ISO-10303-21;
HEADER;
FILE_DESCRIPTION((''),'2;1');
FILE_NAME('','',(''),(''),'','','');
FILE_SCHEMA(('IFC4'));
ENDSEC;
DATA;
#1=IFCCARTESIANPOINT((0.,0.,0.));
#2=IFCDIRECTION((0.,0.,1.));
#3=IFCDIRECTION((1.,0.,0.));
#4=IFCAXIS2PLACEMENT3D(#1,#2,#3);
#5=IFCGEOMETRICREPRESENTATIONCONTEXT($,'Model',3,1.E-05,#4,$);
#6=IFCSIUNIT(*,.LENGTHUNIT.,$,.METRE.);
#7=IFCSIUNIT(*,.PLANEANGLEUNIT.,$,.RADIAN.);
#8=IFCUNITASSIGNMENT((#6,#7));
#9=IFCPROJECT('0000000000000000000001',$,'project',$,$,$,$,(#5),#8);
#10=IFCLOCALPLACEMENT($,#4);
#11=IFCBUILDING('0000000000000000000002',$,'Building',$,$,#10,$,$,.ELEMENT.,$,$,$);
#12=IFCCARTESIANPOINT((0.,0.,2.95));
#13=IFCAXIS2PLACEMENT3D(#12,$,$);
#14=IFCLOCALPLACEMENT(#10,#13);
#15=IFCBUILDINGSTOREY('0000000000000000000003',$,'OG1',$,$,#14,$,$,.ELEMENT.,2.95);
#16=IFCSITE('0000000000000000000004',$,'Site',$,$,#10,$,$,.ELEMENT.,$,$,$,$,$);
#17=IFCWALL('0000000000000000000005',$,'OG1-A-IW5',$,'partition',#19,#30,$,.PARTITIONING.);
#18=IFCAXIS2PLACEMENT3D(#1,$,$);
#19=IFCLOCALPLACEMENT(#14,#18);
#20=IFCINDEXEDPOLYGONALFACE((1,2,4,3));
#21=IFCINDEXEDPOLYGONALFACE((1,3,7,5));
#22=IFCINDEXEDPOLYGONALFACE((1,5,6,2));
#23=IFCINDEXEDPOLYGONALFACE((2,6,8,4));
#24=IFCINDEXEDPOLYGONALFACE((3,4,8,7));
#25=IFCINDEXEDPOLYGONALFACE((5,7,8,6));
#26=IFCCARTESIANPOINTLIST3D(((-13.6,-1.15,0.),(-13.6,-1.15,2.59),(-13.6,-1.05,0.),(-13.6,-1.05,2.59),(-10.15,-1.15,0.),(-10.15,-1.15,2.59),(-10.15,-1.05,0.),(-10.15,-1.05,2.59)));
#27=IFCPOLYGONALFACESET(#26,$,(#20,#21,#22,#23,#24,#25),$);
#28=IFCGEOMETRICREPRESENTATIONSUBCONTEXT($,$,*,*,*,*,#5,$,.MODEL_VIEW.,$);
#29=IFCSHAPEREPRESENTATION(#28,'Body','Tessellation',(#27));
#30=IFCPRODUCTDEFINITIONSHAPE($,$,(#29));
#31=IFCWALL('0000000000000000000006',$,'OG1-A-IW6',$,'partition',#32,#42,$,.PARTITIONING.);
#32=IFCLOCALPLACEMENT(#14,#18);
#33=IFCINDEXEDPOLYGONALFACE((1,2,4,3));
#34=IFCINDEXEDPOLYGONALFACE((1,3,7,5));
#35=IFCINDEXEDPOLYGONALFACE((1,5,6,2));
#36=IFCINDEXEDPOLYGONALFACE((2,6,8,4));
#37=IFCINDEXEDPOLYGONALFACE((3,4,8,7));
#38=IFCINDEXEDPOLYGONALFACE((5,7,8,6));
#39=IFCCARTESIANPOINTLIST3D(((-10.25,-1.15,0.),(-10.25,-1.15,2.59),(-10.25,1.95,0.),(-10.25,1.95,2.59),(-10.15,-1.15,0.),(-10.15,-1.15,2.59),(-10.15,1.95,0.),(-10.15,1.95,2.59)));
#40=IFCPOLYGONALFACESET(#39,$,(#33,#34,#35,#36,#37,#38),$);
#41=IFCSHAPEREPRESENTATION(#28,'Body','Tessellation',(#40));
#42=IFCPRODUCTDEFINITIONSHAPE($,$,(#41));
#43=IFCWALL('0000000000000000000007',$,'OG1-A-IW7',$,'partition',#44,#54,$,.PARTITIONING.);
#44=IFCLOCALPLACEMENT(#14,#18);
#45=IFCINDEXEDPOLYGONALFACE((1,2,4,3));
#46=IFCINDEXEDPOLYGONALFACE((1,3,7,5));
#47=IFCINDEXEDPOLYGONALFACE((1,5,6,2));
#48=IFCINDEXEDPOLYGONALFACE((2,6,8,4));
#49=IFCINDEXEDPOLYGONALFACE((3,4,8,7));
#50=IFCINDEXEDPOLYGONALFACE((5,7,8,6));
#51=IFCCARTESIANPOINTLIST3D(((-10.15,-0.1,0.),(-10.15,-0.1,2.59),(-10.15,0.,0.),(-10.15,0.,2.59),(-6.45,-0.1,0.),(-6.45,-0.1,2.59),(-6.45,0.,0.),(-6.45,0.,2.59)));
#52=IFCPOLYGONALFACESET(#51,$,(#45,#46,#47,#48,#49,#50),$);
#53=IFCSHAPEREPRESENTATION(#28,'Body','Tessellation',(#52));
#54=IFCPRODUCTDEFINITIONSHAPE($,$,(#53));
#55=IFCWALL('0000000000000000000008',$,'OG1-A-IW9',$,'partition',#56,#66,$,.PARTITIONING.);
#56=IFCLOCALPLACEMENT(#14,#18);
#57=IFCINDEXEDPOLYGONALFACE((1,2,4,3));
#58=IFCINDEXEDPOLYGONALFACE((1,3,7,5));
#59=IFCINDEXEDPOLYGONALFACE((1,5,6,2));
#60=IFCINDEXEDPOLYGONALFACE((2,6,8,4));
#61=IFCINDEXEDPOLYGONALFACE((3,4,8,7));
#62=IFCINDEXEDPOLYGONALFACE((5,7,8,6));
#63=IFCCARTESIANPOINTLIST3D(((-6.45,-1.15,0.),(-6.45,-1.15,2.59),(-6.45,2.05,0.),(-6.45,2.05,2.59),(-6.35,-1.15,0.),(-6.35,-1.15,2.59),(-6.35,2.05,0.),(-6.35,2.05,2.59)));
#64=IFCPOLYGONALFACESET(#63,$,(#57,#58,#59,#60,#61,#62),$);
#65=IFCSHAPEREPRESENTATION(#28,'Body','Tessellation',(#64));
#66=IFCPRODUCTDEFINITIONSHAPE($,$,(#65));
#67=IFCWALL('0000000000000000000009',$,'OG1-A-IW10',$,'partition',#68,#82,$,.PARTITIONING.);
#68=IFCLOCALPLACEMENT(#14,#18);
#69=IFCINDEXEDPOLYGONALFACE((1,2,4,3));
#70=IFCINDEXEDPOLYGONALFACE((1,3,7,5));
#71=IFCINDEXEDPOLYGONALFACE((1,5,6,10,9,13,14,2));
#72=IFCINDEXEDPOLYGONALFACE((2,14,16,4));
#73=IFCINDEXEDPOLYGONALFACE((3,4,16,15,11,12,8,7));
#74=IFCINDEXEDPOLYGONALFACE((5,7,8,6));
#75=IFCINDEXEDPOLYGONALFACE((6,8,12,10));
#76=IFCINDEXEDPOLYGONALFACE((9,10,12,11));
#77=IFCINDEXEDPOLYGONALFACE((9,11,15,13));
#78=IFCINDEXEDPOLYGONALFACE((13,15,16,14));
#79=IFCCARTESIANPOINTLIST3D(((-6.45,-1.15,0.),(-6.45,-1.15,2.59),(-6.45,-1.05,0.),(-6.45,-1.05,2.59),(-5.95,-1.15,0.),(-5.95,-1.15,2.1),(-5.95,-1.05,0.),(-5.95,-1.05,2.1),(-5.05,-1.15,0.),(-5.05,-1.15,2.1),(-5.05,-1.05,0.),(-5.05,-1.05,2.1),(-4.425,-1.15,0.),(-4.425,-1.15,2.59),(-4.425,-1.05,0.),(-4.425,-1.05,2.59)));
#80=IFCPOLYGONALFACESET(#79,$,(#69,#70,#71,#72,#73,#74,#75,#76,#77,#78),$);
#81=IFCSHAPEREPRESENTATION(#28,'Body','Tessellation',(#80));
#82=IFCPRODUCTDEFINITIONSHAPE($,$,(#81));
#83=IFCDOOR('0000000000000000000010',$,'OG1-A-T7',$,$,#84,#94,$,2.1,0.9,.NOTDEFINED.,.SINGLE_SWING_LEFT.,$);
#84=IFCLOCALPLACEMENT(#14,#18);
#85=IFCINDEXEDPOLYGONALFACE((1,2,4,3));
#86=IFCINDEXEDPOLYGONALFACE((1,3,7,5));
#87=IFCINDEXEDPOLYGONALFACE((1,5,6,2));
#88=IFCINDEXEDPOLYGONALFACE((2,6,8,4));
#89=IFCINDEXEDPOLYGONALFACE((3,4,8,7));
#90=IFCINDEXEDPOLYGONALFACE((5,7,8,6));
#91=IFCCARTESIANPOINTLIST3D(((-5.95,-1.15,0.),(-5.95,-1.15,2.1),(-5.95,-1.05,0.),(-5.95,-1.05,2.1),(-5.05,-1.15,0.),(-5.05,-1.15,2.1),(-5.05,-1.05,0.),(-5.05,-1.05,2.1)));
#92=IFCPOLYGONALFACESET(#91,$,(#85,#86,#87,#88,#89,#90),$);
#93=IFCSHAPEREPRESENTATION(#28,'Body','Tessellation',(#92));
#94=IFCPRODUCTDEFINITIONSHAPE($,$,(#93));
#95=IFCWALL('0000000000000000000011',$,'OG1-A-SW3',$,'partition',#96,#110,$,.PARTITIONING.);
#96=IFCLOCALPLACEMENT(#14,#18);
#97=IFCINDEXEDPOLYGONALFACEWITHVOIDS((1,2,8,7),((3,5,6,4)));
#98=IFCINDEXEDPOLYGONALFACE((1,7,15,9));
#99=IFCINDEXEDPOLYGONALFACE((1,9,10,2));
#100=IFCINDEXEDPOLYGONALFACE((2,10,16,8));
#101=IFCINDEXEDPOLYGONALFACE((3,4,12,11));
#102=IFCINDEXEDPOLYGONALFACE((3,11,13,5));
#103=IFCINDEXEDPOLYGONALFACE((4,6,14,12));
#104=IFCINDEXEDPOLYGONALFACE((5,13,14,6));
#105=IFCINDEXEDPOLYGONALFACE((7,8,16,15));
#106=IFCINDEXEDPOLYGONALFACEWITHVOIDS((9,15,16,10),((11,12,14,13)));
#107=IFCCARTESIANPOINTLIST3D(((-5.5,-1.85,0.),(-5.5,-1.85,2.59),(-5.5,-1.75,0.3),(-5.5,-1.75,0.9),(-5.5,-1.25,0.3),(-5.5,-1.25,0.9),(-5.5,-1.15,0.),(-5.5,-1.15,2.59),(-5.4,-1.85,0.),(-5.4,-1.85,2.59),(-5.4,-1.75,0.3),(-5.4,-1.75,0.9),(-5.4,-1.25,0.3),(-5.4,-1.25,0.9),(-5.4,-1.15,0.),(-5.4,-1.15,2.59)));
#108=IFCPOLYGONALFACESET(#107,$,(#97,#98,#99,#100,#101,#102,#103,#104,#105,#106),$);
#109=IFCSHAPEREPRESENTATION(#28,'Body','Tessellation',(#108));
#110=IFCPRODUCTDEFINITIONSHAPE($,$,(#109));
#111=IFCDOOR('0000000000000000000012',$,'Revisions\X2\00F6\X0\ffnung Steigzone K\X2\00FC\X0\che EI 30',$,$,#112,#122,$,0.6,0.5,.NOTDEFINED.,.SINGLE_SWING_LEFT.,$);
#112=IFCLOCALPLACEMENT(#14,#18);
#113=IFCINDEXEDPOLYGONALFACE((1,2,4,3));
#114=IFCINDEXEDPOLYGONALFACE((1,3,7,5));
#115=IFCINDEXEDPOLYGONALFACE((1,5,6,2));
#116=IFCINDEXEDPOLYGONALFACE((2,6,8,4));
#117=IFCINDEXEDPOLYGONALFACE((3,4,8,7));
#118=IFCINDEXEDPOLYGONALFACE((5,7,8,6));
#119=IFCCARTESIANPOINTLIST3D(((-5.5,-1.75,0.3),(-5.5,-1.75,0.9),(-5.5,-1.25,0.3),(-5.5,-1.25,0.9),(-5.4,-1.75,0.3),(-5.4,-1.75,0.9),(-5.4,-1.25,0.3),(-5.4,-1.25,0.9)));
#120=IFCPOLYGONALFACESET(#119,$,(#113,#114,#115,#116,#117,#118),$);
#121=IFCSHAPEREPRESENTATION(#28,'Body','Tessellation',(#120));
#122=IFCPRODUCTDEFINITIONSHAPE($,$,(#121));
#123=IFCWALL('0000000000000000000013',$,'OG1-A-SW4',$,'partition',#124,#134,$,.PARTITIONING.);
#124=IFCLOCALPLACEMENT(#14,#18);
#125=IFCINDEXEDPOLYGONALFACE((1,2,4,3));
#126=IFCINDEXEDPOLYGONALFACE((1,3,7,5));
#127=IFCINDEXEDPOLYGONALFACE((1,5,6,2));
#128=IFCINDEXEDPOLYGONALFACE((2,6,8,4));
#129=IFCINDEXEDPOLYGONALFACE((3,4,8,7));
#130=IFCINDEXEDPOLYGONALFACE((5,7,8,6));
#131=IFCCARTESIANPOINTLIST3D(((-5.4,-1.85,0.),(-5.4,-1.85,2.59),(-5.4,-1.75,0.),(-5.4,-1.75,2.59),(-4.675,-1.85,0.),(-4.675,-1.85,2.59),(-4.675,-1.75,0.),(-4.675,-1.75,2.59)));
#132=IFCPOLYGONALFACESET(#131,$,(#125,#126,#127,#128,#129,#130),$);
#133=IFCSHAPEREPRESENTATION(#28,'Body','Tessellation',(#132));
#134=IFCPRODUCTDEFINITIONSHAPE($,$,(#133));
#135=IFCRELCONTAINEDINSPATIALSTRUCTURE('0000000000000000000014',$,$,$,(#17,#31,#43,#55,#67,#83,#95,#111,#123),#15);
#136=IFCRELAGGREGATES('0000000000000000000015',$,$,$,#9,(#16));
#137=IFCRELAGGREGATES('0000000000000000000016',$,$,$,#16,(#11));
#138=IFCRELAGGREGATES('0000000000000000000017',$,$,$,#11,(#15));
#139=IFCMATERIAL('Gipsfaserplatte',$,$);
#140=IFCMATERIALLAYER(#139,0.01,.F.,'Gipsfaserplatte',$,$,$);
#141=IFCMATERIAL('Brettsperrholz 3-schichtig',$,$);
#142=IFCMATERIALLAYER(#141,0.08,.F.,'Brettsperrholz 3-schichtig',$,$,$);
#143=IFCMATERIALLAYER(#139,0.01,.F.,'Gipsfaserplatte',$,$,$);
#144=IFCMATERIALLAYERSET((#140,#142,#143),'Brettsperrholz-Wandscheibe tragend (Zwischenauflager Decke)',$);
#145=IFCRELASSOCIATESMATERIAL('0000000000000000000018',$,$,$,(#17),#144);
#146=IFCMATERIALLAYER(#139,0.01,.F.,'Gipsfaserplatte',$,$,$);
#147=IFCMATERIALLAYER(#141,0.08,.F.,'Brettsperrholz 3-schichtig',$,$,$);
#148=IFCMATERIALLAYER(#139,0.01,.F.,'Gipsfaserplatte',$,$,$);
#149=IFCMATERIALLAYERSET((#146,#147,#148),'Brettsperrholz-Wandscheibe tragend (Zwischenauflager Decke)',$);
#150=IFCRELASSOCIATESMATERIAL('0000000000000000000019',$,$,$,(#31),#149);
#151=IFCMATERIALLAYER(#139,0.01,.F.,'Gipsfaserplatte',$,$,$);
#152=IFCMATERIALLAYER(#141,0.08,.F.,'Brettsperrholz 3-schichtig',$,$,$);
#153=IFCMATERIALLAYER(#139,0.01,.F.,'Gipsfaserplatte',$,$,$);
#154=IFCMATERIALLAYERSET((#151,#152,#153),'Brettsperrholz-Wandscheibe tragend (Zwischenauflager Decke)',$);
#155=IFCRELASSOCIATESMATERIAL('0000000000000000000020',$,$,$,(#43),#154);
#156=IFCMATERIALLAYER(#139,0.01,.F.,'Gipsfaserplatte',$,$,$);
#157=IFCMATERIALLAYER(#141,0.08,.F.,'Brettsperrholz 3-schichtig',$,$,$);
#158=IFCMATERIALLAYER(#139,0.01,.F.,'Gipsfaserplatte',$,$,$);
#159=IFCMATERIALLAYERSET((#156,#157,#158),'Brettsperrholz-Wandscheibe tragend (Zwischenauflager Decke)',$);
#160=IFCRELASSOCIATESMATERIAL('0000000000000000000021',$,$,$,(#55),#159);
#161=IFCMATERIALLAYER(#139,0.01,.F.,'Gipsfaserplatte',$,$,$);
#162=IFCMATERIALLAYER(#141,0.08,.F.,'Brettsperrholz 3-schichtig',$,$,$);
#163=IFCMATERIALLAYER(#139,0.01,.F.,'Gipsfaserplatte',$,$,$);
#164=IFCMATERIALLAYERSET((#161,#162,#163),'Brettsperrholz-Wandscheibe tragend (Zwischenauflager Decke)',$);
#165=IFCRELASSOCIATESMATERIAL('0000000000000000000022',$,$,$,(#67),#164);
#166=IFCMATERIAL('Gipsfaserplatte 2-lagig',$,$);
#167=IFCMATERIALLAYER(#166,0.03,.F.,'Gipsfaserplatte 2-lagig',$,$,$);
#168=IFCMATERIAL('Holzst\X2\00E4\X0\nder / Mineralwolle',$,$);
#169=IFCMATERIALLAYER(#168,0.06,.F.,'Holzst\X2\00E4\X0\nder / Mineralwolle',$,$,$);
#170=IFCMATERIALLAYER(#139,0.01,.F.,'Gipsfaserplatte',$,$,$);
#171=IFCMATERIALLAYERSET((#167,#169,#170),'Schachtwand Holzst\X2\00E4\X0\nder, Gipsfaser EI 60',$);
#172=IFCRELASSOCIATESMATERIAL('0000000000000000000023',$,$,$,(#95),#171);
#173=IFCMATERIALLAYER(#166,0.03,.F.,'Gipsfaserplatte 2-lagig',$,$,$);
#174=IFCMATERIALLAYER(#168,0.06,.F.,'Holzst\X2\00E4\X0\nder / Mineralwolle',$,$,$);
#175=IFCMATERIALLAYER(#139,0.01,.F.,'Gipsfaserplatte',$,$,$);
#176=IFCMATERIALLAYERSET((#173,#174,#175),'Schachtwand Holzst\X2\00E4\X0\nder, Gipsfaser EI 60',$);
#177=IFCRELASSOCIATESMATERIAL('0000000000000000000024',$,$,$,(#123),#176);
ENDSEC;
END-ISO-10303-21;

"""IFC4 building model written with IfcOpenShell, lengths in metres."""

from ifc_helpers import new_model, si_unit, frame, frame_2d, origin, origin_with_axes, place, context, subcontext, project, spatial, rectangle, extrude, material, layer, layer_set, element, fill, save


model = new_model("IFC4")

# Units and contexts
model_context = context("Model", 3, precision=1e-05, world=origin_with_axes())
sub_context = subcontext(model_context, None, None, "MODEL_VIEW")
ifc_project = project(units=[si_unit("LENGTHUNIT", "METRE"), si_unit("PLANEANGLEUNIT", "RADIAN")], contexts=[model_context])

# Site, building, storey
placement = place(None, origin_with_axes())
site = spatial("IfcSite", under=ifc_project, at=placement, Name="Site", CompositionType="ELEMENT")
building = spatial("IfcBuilding", under=site, at=placement, Name="Building", CompositionType="ELEMENT")
storey_placement = place(placement, frame((0.0, 0.0, 2.95)))
storey = spatial("IfcBuildingStorey", under=building, at=storey_placement, Name="OG1", CompositionType="ELEMENT", Elevation=2.95)

# Shared definitions
ifc_material_1 = material(Name="Gipsfaserplatte")

# Walls
ifc_layer_1 = layer(ifc_material_1, 0.01, ventilated=False, Name="Gipsfaserplatte")
ifc_material_2 = material(Name="Brettsperrholz 3-schichtig")
ifc_layer_2 = layer(ifc_material_2, 0.08, ventilated=False, Name="Brettsperrholz 3-schichtig")
ifc_layer_3 = layer(ifc_material_1, 0.01, ventilated=False, Name="Gipsfaserplatte")
ifc_layer_set_1 = layer_set([ifc_layer_1, ifc_layer_2, ifc_layer_3], Name="Brettsperrholz-Wandscheibe tragend (Zwischenauflager Decke)")
wall_1_placement = place(storey_placement, frame((-13.6, -1.1, 0.0), z_axis=(0.0, 0.0, 1.0), x_axis=(1.0, 0.0, 0.0)))
element("IfcWall", 1, at=wall_1_placement, inside=storey, material=ifc_layer_set_1, Name="OG1-A-IW5", ObjectType="partition", PredefinedType="PARTITIONING", context=sub_context, shape_type="SweptSolid", body=[
    extrude(rectangle(XDim=3.45, YDim=0.1, at=frame_2d((1.725, 0.0))), origin(), (0.0, 0.0, 1.0), 2.59),
])
ifc_layer_4 = layer(ifc_material_1, 0.01, ventilated=False, Name="Gipsfaserplatte")
ifc_layer_5 = layer(ifc_material_2, 0.08, ventilated=False, Name="Brettsperrholz 3-schichtig")
ifc_layer_6 = layer(ifc_material_1, 0.01, ventilated=False, Name="Gipsfaserplatte")
ifc_layer_set_2 = layer_set([ifc_layer_4, ifc_layer_5, ifc_layer_6], Name="Brettsperrholz-Wandscheibe tragend (Zwischenauflager Decke)")
wall_2_placement = place(storey_placement, frame((-10.2, -1.15, 0.0), z_axis=(0.0, 0.0, 1.0), x_axis=(0.0, 1.0, 0.0)))
element("IfcWall", 2, at=wall_2_placement, inside=storey, material=ifc_layer_set_2, Name="OG1-A-IW6", ObjectType="partition", PredefinedType="PARTITIONING", context=sub_context, shape_type="SweptSolid", body=[
    extrude(rectangle(XDim=3.1, YDim=0.1, at=frame_2d((1.55, 0.0))), origin(), (0.0, 0.0, 1.0), 2.59),
])
ifc_layer_7 = layer(ifc_material_1, 0.01, ventilated=False, Name="Gipsfaserplatte")
ifc_layer_8 = layer(ifc_material_2, 0.08, ventilated=False, Name="Brettsperrholz 3-schichtig")
ifc_layer_9 = layer(ifc_material_1, 0.01, ventilated=False, Name="Gipsfaserplatte")
ifc_layer_set_3 = layer_set([ifc_layer_7, ifc_layer_8, ifc_layer_9], Name="Brettsperrholz-Wandscheibe tragend (Zwischenauflager Decke)")
wall_3_placement = place(storey_placement, frame((-10.15, -0.05, 0.0), z_axis=(0.0, 0.0, 1.0), x_axis=(1.0, 0.0, 0.0)))
element("IfcWall", 3, at=wall_3_placement, inside=storey, material=ifc_layer_set_3, Name="OG1-A-IW7", ObjectType="partition", PredefinedType="PARTITIONING", context=sub_context, shape_type="SweptSolid", body=[
    extrude(rectangle(XDim=3.7, YDim=0.1, at=frame_2d((1.85, 0.0))), origin(), (0.0, 0.0, 1.0), 2.59),
])
ifc_layer_10 = layer(ifc_material_1, 0.01, ventilated=False, Name="Gipsfaserplatte")
ifc_layer_11 = layer(ifc_material_2, 0.08, ventilated=False, Name="Brettsperrholz 3-schichtig")
ifc_layer_12 = layer(ifc_material_1, 0.01, ventilated=False, Name="Gipsfaserplatte")
ifc_layer_set_4 = layer_set([ifc_layer_10, ifc_layer_11, ifc_layer_12], Name="Brettsperrholz-Wandscheibe tragend (Zwischenauflager Decke)")
wall_4_placement = place(storey_placement, frame((-6.4, -1.15, 0.0), z_axis=(0.0, 0.0, 1.0), x_axis=(0.0, 1.0, 0.0)))
element("IfcWall", 4, at=wall_4_placement, inside=storey, material=ifc_layer_set_4, Name="OG1-A-IW9", ObjectType="partition", PredefinedType="PARTITIONING", context=sub_context, shape_type="SweptSolid", body=[
    extrude(rectangle(XDim=3.2, YDim=0.1, at=frame_2d((1.6, 0.0))), origin(), (0.0, 0.0, 1.0), 2.59),
])

# Walls, openings, doors
ifc_layer_13 = layer(ifc_material_1, 0.01, ventilated=False, Name="Gipsfaserplatte")
ifc_layer_14 = layer(ifc_material_2, 0.08, ventilated=False, Name="Brettsperrholz 3-schichtig")
ifc_layer_15 = layer(ifc_material_1, 0.01, ventilated=False, Name="Gipsfaserplatte")
ifc_layer_set_5 = layer_set([ifc_layer_13, ifc_layer_14, ifc_layer_15], Name="Brettsperrholz-Wandscheibe tragend (Zwischenauflager Decke)")
wall_5_placement = place(storey_placement, frame((-6.45, -1.1, 0.0), z_axis=(0.0, 0.0, 1.0), x_axis=(1.0, 0.0, 0.0)))
wall_5 = element("IfcWall", 5, at=wall_5_placement, inside=storey, material=ifc_layer_set_5, Name="OG1-A-IW10", ObjectType="partition", PredefinedType="PARTITIONING", context=sub_context, shape_type="SweptSolid", body=[
    extrude(rectangle(XDim=2.025, YDim=0.1, at=frame_2d((1.0125, 0.0))), origin(), (0.0, 0.0, 1.0), 2.59),
])
opening_1_placement = place(wall_5_placement, frame((0.95, 0.1, 0.0), z_axis=(0.0, -1.0, 0.0), x_axis=(1.0, 0.0, 0.0)))
opening_1 = element("IfcOpeningElement", 6, at=opening_1_placement, cuts=wall_5, PredefinedType="OPENING", context=sub_context, shape_type="SweptSolid", body=[
    extrude(rectangle(XDim=0.9, YDim=2.1, at=frame_2d((0.0, 1.05))), origin(), (0.0, 0.0, 1.0), 0.2),
])
door_1_placement = place(wall_5_placement, frame((0.95, 0.05, 0.0), z_axis=(0.0, -1.0, 0.0), x_axis=(1.0, 0.0, 0.0)))
door_1 = element("IfcDoor", 7, at=door_1_placement, inside=storey, Name="OG1-A-T7", OperationType="SINGLE_SWING_LEFT", OverallHeight=2.1, OverallWidth=0.9, PredefinedType="NOTDEFINED", context=sub_context, shape_type="SweptSolid", body=[
    extrude(rectangle(XDim=0.9, YDim=2.1, at=frame_2d((0.0, 1.05))), origin(), (0.0, 0.0, 1.0), 0.1),
])
fill(opening_1, door_1)
ifc_material_3 = material(Name="Gipsfaserplatte 2-lagig")
ifc_layer_16 = layer(ifc_material_3, 0.03, ventilated=False, Name="Gipsfaserplatte 2-lagig")
ifc_material_4 = material(Name="Holzständer / Mineralwolle")
ifc_layer_17 = layer(ifc_material_4, 0.06, ventilated=False, Name="Holzständer / Mineralwolle")
ifc_layer_18 = layer(ifc_material_1, 0.01, ventilated=False, Name="Gipsfaserplatte")
ifc_layer_set_6 = layer_set([ifc_layer_16, ifc_layer_17, ifc_layer_18], Name="Schachtwand Holzständer, Gipsfaser EI 60")
wall_6_placement = place(storey_placement, frame((-5.45, -1.85, 0.0), z_axis=(0.0, 0.0, 1.0), x_axis=(0.0, 1.0, 0.0)))
wall_6 = element("IfcWall", 8, at=wall_6_placement, inside=storey, material=ifc_layer_set_6, Name="OG1-A-SW3", ObjectType="partition", PredefinedType="PARTITIONING", context=sub_context, shape_type="SweptSolid", body=[
    extrude(rectangle(XDim=0.7, YDim=0.1, at=frame_2d((0.35, 0.0))), origin(), (0.0, 0.0, 1.0), 2.59),
])
opening_2_placement = place(wall_6_placement, frame((0.35, 0.1, 0.3), z_axis=(0.0, -1.0, 0.0), x_axis=(1.0, 0.0, 0.0)))
opening_2 = element("IfcOpeningElement", 9, at=opening_2_placement, cuts=wall_6, PredefinedType="OPENING", context=sub_context, shape_type="SweptSolid", body=[
    extrude(rectangle(XDim=0.5, YDim=0.6, at=frame_2d((0.0, 0.3))), origin(), (0.0, 0.0, 1.0), 0.2),
])
door_2_placement = place(wall_6_placement, frame((0.35, 0.05, 0.3), z_axis=(0.0, -1.0, 0.0), x_axis=(1.0, 0.0, 0.0)))
door_2 = element("IfcDoor", 10, at=door_2_placement, inside=storey, Name="Revisionsöffnung Steigzone Küche EI 30", OperationType="SINGLE_SWING_LEFT", OverallHeight=0.6, OverallWidth=0.5, PredefinedType="NOTDEFINED", context=sub_context, shape_type="SweptSolid", body=[
    extrude(rectangle(XDim=0.5, YDim=0.6, at=frame_2d((0.0, 0.3))), origin(), (0.0, 0.0, 1.0), 0.1),
])
fill(opening_2, door_2)

# Wall
ifc_layer_19 = layer(ifc_material_3, 0.03, ventilated=False, Name="Gipsfaserplatte 2-lagig")
ifc_layer_20 = layer(ifc_material_4, 0.06, ventilated=False, Name="Holzständer / Mineralwolle")
ifc_layer_21 = layer(ifc_material_1, 0.01, ventilated=False, Name="Gipsfaserplatte")
ifc_layer_set_7 = layer_set([ifc_layer_19, ifc_layer_20, ifc_layer_21], Name="Schachtwand Holzständer, Gipsfaser EI 60")
wall_7_placement = place(storey_placement, frame((-5.4, -1.8, 0.0), z_axis=(0.0, 0.0, 1.0), x_axis=(1.0, 0.0, 0.0)))
element("IfcWall", 11, at=wall_7_placement, inside=storey, material=ifc_layer_set_7, Name="OG1-A-SW4", ObjectType="partition", PredefinedType="PARTITIONING", context=sub_context, shape_type="SweptSolid", body=[
    extrude(rectangle(XDim=0.725, YDim=0.1, at=frame_2d((0.3625, 0.0))), origin(), (0.0, 0.0, 1.0), 2.59),
])

save(model, "model.ifc")
